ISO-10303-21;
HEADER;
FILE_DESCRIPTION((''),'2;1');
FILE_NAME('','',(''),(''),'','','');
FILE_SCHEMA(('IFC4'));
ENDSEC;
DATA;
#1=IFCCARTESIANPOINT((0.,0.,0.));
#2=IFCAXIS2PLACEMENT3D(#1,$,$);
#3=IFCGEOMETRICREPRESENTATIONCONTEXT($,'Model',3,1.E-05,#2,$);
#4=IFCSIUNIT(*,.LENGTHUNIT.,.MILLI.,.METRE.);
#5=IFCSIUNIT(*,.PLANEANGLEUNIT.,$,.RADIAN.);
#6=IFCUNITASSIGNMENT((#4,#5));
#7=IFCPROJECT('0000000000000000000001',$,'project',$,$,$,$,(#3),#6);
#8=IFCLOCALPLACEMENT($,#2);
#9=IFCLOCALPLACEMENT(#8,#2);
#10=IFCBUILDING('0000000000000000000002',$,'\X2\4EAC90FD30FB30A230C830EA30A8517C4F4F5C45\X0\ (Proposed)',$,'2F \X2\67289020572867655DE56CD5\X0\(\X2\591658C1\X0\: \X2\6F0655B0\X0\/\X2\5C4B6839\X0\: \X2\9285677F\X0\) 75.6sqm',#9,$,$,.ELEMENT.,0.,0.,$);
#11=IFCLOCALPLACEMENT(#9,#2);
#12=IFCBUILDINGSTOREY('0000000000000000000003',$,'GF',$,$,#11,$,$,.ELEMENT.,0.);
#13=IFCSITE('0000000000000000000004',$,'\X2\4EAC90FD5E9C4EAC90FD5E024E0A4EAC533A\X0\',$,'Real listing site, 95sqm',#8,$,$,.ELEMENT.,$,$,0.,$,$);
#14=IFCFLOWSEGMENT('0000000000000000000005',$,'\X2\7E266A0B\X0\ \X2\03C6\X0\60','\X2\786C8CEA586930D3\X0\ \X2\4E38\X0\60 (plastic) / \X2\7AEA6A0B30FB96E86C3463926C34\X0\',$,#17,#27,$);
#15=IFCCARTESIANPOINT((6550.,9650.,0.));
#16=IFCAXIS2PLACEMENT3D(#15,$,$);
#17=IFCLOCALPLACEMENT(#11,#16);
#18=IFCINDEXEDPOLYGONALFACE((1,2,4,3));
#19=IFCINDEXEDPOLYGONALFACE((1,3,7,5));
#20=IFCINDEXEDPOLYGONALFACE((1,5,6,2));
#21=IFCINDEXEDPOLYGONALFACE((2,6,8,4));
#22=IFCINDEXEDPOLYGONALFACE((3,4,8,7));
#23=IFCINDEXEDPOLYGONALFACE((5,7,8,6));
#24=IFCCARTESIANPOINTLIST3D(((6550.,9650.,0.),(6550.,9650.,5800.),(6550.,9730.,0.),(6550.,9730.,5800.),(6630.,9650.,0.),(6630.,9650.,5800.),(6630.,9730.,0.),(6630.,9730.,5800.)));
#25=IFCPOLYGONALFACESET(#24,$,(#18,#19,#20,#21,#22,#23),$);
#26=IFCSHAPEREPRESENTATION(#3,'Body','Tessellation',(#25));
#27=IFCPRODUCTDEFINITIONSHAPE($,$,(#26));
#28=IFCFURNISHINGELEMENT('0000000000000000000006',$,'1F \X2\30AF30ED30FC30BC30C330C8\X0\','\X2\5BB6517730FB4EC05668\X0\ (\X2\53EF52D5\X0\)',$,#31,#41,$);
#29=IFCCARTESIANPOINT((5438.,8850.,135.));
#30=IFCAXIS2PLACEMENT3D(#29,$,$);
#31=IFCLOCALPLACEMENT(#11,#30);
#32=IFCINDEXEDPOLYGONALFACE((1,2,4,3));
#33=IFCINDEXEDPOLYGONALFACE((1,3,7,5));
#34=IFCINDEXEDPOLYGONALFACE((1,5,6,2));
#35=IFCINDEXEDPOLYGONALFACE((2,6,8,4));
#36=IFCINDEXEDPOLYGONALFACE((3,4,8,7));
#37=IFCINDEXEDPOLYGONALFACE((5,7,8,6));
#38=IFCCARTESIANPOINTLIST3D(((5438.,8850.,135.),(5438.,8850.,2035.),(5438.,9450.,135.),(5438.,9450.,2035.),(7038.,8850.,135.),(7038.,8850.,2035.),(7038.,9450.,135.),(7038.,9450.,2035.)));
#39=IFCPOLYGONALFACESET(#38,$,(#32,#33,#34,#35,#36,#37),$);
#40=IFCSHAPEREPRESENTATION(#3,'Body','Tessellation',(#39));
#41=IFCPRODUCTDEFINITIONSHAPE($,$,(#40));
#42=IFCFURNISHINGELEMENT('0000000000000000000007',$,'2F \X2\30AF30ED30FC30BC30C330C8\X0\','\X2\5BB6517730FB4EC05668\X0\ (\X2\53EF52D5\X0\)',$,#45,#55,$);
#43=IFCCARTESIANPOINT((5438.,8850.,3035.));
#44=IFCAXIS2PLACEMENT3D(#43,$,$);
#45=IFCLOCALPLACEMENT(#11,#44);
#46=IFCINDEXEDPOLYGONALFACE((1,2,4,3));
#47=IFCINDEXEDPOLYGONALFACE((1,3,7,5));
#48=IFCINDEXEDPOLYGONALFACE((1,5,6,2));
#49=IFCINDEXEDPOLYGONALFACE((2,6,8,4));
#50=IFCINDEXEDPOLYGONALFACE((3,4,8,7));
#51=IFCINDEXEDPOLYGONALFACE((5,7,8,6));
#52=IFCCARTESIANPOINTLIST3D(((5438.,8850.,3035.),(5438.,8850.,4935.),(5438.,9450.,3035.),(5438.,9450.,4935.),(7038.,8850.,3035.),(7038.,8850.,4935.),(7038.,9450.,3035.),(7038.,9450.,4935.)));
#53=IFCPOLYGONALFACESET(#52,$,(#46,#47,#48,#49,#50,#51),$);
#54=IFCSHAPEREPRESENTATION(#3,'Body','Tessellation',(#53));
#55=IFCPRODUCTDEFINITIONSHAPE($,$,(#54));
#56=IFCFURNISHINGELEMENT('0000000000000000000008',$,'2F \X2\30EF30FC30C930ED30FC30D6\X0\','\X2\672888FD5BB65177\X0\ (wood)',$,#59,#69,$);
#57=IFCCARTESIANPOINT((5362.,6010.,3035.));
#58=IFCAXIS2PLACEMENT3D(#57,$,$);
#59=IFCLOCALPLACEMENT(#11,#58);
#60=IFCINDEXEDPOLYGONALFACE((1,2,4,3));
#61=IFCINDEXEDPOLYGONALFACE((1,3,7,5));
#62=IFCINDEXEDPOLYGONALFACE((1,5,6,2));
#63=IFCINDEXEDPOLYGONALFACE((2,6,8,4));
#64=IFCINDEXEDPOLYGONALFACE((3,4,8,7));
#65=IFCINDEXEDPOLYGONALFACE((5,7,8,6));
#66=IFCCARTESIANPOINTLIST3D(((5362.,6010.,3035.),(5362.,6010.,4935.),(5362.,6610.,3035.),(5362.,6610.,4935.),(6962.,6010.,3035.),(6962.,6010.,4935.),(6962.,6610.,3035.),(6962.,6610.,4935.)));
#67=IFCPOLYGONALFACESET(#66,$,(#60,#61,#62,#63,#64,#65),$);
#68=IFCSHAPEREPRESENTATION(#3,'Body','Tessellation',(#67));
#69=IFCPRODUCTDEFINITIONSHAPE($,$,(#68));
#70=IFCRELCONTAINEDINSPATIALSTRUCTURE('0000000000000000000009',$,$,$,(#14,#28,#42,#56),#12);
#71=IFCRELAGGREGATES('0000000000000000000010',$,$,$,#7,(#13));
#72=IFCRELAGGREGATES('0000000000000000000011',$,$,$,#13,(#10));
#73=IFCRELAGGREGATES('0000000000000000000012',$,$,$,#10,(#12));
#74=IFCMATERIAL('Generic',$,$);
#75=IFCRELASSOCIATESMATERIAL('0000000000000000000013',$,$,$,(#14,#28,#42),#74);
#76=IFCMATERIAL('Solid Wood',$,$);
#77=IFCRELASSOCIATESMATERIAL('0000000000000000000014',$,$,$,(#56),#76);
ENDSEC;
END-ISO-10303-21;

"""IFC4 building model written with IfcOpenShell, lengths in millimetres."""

from ifc_helpers import new_model, si_unit, frame, frame_2d, origin, place, context, project, spatial, rectangle, extrude, material, element, save


model = new_model("IFC4")

# Units and contexts
model_context = context("Model", 3, precision=1e-05, world=origin())
ifc_project = project(units=[si_unit("LENGTHUNIT", "METRE", prefix="MILLI"), si_unit("PLANEANGLEUNIT", "RADIAN")], contexts=[model_context])

# Site, building, storey
site_placement = place(None, origin())
site = spatial("IfcSite", under=ifc_project, at=site_placement, Name="京都府京都市上京区", ObjectType="Real listing site, 95sqm", CompositionType="ELEMENT", RefElevation=0.0)
building_placement = place(site_placement, origin())
building = spatial("IfcBuilding", under=site, at=building_placement, Name="京都・アトリエ兼住居 (Proposed)", ObjectType="2F 木造在来工法(外壁: 漆喰/屋根: 銅板) 75.6sqm", CompositionType="ELEMENT", ElevationOfRefHeight=0.0, ElevationOfTerrain=0.0)
storey_placement = place(building_placement, origin())
storey = spatial("IfcBuildingStorey", under=building, at=storey_placement, Name="GF", CompositionType="ELEMENT", Elevation=0.0)

# Shared definitions
ifc_material_1 = material(Name="Solid Wood")

# Shared definitions
ifc_material_2 = material(Name="Generic")

# Flow segment
flow_segment_placement = place(storey_placement, frame((6550.0, 9650.0, 0.0)))
element("IfcFlowSegment", 1, at=flow_segment_placement, inside=storey, material=ifc_material_2, Name="縦樋 φ60", Description="硬質塩ビ 丸60 (plastic) / 竪樋・雨水排水", context=model_context, shape_type="SweptSolid", body=[
    extrude(rectangle(XDim=80.0, YDim=80.0, at=frame_2d((40.0, 40.0))), frame((6550.0, 9650.0, 0.0)), (0.0, 0.0, 1.0), 5800.0),
])

# Furnishing elements
furnishing_1_placement = place(storey_placement, frame((5438.0, 8850.0, 135.0)))
element("IfcFurnishingElement", 2, at=furnishing_1_placement, inside=storey, material=ifc_material_2, Name="1F クローゼット", Description="家具・什器 (可動)", context=model_context, shape_type="SweptSolid", body=[
    extrude(rectangle(XDim=1600.0, YDim=600.0, at=frame_2d((800.0, 300.0))), frame((5438.0, 8850.0, 135.0)), (0.0, 0.0, 1.0), 1900.0),
])
furnishing_2_placement = place(storey_placement, frame((5438.0, 8850.0, 3035.0)))
element("IfcFurnishingElement", 3, at=furnishing_2_placement, inside=storey, material=ifc_material_2, Name="2F クローゼット", Description="家具・什器 (可動)", context=model_context, shape_type="SweptSolid", body=[
    extrude(rectangle(XDim=1600.0, YDim=600.0, at=frame_2d((800.0, 300.0))), frame((5438.0, 8850.0, 3035.0)), (0.0, 0.0, 1.0), 1900.0),
])
furnishing_3_placement = place(storey_placement, frame((5362.0, 6010.0, 3035.0)))
element("IfcFurnishingElement", 4, at=furnishing_3_placement, inside=storey, material=ifc_material_1, Name="2F ワードローブ", Description="木製家具 (wood)", context=model_context, shape_type="SweptSolid", body=[
    extrude(rectangle(XDim=1600.0, YDim=600.0, at=frame_2d((800.0, 300.0))), frame((5362.0, 6010.0, 3035.0)), (0.0, 0.0, 1.0), 1900.0),
])

save(model, "model.ifc")
